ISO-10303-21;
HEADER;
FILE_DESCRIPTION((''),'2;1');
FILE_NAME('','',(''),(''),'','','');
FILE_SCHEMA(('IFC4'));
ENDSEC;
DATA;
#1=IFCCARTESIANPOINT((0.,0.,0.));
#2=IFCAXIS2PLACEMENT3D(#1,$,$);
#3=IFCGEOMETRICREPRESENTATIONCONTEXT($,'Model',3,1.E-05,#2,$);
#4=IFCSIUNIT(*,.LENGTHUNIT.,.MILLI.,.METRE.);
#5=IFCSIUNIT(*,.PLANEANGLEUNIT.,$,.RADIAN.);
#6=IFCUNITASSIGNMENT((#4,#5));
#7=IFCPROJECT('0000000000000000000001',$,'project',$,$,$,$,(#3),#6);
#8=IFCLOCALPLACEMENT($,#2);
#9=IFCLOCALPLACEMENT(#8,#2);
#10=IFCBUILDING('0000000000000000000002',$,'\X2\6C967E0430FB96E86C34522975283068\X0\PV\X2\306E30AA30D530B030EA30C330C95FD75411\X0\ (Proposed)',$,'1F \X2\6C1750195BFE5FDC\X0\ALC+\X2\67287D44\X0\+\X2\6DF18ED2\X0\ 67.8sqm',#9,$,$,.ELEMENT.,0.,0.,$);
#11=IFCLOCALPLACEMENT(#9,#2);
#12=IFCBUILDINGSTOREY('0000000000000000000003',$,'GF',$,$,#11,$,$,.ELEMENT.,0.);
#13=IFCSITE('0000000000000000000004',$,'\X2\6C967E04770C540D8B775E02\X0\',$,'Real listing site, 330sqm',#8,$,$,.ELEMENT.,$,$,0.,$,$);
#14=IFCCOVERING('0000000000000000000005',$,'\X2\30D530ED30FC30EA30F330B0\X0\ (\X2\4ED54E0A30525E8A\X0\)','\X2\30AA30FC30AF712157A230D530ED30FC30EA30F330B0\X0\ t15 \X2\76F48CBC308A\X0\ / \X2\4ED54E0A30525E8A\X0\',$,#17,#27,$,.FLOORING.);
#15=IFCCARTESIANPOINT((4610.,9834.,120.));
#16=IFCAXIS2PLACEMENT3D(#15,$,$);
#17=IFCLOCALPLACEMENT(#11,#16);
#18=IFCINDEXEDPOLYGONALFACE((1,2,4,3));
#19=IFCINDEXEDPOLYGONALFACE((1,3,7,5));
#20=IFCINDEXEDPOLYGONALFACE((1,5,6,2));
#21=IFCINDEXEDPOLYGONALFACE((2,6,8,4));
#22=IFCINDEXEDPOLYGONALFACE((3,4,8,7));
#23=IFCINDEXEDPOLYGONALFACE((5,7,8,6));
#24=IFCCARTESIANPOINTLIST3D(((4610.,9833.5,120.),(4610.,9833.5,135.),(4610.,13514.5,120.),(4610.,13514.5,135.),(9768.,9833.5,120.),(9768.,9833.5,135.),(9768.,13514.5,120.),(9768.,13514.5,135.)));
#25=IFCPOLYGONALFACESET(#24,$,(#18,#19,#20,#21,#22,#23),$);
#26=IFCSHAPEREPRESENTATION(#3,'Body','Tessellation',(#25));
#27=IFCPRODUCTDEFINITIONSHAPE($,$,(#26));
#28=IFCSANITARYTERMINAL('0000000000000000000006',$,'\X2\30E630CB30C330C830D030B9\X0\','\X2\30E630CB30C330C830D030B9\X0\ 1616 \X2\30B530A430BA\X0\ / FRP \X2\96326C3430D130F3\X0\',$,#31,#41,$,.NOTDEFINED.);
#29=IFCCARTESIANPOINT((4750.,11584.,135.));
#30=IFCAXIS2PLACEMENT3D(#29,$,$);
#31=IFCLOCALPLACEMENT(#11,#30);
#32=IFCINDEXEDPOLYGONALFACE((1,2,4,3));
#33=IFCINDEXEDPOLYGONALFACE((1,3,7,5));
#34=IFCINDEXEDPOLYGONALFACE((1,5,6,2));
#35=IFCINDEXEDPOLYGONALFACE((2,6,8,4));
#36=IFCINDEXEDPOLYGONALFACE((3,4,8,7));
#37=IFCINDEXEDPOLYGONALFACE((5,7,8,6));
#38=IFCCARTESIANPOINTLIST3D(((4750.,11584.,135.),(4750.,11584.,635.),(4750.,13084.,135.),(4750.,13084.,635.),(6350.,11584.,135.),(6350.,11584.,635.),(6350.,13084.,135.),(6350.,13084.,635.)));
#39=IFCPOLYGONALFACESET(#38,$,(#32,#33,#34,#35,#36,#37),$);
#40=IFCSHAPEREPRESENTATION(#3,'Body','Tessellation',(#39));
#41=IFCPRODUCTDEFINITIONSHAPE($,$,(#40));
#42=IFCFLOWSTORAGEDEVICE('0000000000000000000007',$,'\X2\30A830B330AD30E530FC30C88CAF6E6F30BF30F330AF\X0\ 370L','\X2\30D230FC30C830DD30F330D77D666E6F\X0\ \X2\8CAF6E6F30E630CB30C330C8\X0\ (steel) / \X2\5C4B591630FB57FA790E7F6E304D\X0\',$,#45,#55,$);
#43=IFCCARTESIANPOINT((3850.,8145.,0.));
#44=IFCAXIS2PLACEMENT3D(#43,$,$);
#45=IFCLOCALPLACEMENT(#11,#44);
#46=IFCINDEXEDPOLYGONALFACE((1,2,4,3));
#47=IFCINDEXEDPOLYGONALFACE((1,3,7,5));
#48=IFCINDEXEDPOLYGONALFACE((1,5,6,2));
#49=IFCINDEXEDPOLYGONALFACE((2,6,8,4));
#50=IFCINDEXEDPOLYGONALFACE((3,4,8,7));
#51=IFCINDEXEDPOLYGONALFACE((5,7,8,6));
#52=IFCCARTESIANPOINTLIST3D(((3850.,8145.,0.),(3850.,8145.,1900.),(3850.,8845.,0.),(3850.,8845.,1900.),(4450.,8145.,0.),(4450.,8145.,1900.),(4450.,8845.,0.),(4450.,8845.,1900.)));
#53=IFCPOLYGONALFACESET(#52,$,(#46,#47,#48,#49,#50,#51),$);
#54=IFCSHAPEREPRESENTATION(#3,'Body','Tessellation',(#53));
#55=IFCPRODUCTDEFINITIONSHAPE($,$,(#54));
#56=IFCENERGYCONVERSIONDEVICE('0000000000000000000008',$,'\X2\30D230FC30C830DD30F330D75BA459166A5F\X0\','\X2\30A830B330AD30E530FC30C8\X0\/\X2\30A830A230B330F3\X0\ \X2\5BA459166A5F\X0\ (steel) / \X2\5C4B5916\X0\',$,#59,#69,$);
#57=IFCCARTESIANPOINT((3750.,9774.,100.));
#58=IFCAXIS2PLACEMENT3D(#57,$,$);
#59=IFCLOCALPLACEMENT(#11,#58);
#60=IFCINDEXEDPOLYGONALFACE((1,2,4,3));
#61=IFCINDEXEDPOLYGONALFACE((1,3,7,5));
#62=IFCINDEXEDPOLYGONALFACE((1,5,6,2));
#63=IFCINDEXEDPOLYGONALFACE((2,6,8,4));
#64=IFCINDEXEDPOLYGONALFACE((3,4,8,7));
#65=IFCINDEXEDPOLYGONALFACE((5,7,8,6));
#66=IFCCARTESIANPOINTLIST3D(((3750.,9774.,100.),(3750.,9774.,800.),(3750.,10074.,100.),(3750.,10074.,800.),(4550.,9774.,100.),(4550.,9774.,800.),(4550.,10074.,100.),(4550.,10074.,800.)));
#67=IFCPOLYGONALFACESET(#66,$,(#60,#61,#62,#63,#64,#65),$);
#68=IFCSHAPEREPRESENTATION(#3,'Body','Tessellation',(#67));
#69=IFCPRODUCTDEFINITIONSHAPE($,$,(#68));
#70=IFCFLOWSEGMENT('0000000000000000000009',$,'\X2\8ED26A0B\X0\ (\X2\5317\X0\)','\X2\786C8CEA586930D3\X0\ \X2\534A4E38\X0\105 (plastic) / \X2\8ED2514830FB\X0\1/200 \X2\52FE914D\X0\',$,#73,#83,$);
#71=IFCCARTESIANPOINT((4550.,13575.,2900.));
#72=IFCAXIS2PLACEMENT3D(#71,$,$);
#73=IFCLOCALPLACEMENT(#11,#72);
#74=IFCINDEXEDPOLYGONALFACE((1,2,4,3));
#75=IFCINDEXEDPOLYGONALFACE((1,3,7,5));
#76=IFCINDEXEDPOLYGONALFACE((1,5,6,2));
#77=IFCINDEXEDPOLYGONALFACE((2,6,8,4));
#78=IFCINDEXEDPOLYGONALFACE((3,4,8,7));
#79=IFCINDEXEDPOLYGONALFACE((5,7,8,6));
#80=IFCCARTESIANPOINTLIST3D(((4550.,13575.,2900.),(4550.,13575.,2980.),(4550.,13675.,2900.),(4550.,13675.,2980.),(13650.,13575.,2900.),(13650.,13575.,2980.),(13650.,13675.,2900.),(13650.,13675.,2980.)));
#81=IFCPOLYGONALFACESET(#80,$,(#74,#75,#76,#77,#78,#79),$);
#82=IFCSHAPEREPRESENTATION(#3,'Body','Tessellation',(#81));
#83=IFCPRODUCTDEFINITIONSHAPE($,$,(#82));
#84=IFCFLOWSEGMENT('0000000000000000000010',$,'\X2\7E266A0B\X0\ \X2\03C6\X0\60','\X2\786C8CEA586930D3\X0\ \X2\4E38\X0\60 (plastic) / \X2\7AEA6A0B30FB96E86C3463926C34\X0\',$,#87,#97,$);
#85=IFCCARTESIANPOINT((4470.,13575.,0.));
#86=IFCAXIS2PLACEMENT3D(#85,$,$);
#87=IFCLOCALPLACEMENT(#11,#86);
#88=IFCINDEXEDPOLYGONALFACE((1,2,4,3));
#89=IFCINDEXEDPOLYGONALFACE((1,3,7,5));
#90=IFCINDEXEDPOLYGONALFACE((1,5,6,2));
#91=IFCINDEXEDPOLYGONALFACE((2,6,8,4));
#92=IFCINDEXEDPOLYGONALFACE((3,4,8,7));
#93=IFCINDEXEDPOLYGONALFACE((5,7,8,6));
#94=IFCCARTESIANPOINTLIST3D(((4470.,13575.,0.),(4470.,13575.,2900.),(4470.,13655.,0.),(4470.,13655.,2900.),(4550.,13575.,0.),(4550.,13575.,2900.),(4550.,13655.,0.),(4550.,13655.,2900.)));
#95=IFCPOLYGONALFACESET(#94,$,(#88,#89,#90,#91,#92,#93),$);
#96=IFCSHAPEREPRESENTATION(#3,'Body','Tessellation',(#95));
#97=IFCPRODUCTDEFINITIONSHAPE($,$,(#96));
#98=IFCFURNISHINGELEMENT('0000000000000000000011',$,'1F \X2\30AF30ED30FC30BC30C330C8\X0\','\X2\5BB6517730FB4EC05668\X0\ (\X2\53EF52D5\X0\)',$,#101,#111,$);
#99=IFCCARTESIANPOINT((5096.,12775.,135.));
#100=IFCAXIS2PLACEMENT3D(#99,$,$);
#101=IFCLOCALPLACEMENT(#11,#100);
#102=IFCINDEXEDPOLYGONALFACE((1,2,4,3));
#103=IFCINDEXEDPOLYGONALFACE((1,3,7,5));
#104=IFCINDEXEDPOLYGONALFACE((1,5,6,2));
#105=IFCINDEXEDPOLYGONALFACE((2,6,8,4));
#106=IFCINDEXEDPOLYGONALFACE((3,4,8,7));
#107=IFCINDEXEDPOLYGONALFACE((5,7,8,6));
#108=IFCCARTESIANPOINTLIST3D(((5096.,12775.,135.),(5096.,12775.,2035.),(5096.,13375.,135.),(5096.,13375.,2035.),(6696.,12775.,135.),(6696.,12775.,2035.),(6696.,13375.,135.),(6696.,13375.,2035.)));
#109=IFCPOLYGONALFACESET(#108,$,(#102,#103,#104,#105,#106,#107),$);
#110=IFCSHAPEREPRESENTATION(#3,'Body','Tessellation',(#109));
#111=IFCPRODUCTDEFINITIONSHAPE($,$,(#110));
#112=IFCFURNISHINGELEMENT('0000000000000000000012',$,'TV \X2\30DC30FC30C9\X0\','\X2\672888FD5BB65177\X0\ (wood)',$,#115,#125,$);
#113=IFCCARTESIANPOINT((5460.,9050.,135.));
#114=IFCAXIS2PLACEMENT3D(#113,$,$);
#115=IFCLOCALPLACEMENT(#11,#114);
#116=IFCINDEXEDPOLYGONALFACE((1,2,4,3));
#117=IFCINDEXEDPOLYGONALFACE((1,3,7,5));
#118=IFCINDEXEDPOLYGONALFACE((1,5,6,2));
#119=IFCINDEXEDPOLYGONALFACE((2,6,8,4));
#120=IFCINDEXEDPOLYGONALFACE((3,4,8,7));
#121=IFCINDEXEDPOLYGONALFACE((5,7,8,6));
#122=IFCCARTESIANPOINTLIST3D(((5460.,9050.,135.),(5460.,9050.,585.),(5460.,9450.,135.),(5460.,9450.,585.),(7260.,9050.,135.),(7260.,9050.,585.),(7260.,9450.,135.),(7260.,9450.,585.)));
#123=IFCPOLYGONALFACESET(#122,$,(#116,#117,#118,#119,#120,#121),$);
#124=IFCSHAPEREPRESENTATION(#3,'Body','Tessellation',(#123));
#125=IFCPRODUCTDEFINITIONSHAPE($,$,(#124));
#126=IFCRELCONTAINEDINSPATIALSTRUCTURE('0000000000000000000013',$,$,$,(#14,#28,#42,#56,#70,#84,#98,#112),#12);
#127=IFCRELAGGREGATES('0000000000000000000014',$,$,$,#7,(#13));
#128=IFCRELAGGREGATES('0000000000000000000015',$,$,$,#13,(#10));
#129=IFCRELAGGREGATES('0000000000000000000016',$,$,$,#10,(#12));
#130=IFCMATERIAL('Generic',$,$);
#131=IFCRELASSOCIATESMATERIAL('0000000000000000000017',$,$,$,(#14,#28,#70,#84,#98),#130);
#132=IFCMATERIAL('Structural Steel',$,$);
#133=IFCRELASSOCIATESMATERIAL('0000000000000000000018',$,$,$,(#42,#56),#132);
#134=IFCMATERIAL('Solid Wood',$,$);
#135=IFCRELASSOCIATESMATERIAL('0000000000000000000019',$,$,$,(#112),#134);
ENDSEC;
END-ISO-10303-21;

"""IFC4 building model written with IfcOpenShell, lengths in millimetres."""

from ifc_helpers import new_model, si_unit, frame, frame_2d, origin, place, context, project, spatial, rectangle, extrude, material, element, save


model = new_model("IFC4")

# Units and contexts
model_context = context("Model", 3, precision=1e-05, world=origin())
ifc_project = project(units=[si_unit("LENGTHUNIT", "METRE", prefix="MILLI"), si_unit("PLANEANGLEUNIT", "RADIAN")], contexts=[model_context])

# Site, building, storey
site_placement = place(None, origin())
site = spatial("IfcSite", under=ifc_project, at=site_placement, Name="沖縄県名護市", ObjectType="Real listing site, 330sqm", CompositionType="ELEMENT", RefElevation=0.0)
building_placement = place(site_placement, origin())
building = spatial("IfcBuilding", under=site, at=building_placement, Name="沖縄・雨水利用とPVのオフグリッド志向 (Proposed)", ObjectType="1F 気候対応ALC+木組+深軒 67.8sqm", CompositionType="ELEMENT", ElevationOfRefHeight=0.0, ElevationOfTerrain=0.0)
storey_placement = place(building_placement, origin())
storey = spatial("IfcBuildingStorey", under=building, at=storey_placement, Name="GF", CompositionType="ELEMENT", Elevation=0.0)

# Shared definitions
ifc_material_1 = material(Name="Solid Wood")

# Shared definitions
ifc_material_2 = material(Name="Structural Steel")

# Covering
ifc_material_3 = material(Name="Generic")
covering_placement = place(storey_placement, frame((4610.0, 9834.0, 120.0)))
element("IfcCovering", 1, at=covering_placement, inside=storey, material=ifc_material_3, Name="フローリング (仕上げ床)", Description="オーク無垢フローリング t15 直貼り / 仕上げ床", PredefinedType="FLOORING", context=model_context, shape_type="SweptSolid", body=[
    extrude(rectangle(XDim=5158.0, YDim=3681.0, at=frame_2d((2579.0, 1840.0))), frame((4610.0, 9834.0, 120.0)), (0.0, 0.0, 1.0), 15.0),
])

# Sanitary terminal
sanitary_terminal_placement = place(storey_placement, frame((4750.0, 11584.0, 135.0)))
element("IfcSanitaryTerminal", 2, at=sanitary_terminal_placement, inside=storey, material=ifc_material_3, Name="ユニットバス", Description="ユニットバス 1616 サイズ / FRP 防水パン", PredefinedType="NOTDEFINED", context=model_context, shape_type="SweptSolid", body=[
    extrude(rectangle(XDim=1600.0, YDim=1500.0, at=frame_2d((800.0, 750.0))), frame((4750.0, 11584.0, 135.0)), (0.0, 0.0, 1.0), 500.0),
])

# Flow storage device
flow_storage_device_placement = place(storey_placement, frame((3850.0, 8145.0, 0.0)))
element("IfcFlowStorageDevice", 3, at=flow_storage_device_placement, inside=storey, material=ifc_material_2, Name="エコキュート貯湯タンク 370L", Description="ヒートポンプ給湯 貯湯ユニット (steel) / 屋外・基礎置き", context=model_context, shape_type="SweptSolid", body=[
    extrude(rectangle(XDim=600.0, YDim=700.0, at=frame_2d((300.0, 350.0))), frame((3850.0, 8145.0, 0.0)), (0.0, 0.0, 1.0), 1900.0),
])

# Energy conversion device
energy_conversion_device_placement = place(storey_placement, frame((3750.0, 9774.0, 100.0)))
element("IfcEnergyConversionDevice", 4, at=energy_conversion_device_placement, inside=storey, material=ifc_material_2, Name="ヒートポンプ室外機", Description="エコキュート/エアコン 室外機 (steel) / 屋外", context=model_context, shape_type="SweptSolid", body=[
    extrude(rectangle(XDim=800.0, YDim=300.0, at=frame_2d((400.0, 150.0))), frame((3750.0, 9774.0, 100.0)), (0.0, 0.0, 1.0), 700.0),
])

# Flow segments
flow_segment_1_placement = place(storey_placement, frame((4550.0, 13575.0, 2900.0)))
element("IfcFlowSegment", 5, at=flow_segment_1_placement, inside=storey, material=ifc_material_3, Name="軒樋 (北)", Description="硬質塩ビ 半丸105 (plastic) / 軒先・1/200 勾配", context=model_context, shape_type="SweptSolid", body=[
    extrude(rectangle(XDim=9100.0, YDim=100.0, at=frame_2d((4550.0, 50.0))), frame((4550.0, 13575.0, 2900.0)), (0.0, 0.0, 1.0), 80.0),
])
flow_segment_2_placement = place(storey_placement, frame((4470.0, 13575.0, 0.0)))
element("IfcFlowSegment", 6, at=flow_segment_2_placement, inside=storey, material=ifc_material_3, Name="縦樋 φ60", Description="硬質塩ビ 丸60 (plastic) / 竪樋・雨水排水", context=model_context, shape_type="SweptSolid", body=[
    extrude(rectangle(XDim=80.0, YDim=80.0, at=frame_2d((40.0, 40.0))), frame((4470.0, 13575.0, 0.0)), (0.0, 0.0, 1.0), 2900.0),
])

# Furnishing elements
furnishing_1_placement = place(storey_placement, frame((5096.0, 12775.0, 135.0)))
element("IfcFurnishingElement", 7, at=furnishing_1_placement, inside=storey, material=ifc_material_3, Name="1F クローゼット", Description="家具・什器 (可動)", context=model_context, shape_type="SweptSolid", body=[
    extrude(rectangle(XDim=1600.0, YDim=600.0, at=frame_2d((800.0, 300.0))), frame((5096.0, 12775.0, 135.0)), (0.0, 0.0, 1.0), 1900.0),
])
furnishing_2_placement = place(storey_placement, frame((5460.0, 9050.0, 135.0)))
element("IfcFurnishingElement", 8, at=furnishing_2_placement, inside=storey, material=ifc_material_1, Name="TV ボード", Description="木製家具 (wood)", context=model_context, shape_type="SweptSolid", body=[
    extrude(rectangle(XDim=1800.0, YDim=400.0, at=frame_2d((900.0, 200.0))), frame((5460.0, 9050.0, 135.0)), (0.0, 0.0, 1.0), 450.0),
])

save(model, "model.ifc")
